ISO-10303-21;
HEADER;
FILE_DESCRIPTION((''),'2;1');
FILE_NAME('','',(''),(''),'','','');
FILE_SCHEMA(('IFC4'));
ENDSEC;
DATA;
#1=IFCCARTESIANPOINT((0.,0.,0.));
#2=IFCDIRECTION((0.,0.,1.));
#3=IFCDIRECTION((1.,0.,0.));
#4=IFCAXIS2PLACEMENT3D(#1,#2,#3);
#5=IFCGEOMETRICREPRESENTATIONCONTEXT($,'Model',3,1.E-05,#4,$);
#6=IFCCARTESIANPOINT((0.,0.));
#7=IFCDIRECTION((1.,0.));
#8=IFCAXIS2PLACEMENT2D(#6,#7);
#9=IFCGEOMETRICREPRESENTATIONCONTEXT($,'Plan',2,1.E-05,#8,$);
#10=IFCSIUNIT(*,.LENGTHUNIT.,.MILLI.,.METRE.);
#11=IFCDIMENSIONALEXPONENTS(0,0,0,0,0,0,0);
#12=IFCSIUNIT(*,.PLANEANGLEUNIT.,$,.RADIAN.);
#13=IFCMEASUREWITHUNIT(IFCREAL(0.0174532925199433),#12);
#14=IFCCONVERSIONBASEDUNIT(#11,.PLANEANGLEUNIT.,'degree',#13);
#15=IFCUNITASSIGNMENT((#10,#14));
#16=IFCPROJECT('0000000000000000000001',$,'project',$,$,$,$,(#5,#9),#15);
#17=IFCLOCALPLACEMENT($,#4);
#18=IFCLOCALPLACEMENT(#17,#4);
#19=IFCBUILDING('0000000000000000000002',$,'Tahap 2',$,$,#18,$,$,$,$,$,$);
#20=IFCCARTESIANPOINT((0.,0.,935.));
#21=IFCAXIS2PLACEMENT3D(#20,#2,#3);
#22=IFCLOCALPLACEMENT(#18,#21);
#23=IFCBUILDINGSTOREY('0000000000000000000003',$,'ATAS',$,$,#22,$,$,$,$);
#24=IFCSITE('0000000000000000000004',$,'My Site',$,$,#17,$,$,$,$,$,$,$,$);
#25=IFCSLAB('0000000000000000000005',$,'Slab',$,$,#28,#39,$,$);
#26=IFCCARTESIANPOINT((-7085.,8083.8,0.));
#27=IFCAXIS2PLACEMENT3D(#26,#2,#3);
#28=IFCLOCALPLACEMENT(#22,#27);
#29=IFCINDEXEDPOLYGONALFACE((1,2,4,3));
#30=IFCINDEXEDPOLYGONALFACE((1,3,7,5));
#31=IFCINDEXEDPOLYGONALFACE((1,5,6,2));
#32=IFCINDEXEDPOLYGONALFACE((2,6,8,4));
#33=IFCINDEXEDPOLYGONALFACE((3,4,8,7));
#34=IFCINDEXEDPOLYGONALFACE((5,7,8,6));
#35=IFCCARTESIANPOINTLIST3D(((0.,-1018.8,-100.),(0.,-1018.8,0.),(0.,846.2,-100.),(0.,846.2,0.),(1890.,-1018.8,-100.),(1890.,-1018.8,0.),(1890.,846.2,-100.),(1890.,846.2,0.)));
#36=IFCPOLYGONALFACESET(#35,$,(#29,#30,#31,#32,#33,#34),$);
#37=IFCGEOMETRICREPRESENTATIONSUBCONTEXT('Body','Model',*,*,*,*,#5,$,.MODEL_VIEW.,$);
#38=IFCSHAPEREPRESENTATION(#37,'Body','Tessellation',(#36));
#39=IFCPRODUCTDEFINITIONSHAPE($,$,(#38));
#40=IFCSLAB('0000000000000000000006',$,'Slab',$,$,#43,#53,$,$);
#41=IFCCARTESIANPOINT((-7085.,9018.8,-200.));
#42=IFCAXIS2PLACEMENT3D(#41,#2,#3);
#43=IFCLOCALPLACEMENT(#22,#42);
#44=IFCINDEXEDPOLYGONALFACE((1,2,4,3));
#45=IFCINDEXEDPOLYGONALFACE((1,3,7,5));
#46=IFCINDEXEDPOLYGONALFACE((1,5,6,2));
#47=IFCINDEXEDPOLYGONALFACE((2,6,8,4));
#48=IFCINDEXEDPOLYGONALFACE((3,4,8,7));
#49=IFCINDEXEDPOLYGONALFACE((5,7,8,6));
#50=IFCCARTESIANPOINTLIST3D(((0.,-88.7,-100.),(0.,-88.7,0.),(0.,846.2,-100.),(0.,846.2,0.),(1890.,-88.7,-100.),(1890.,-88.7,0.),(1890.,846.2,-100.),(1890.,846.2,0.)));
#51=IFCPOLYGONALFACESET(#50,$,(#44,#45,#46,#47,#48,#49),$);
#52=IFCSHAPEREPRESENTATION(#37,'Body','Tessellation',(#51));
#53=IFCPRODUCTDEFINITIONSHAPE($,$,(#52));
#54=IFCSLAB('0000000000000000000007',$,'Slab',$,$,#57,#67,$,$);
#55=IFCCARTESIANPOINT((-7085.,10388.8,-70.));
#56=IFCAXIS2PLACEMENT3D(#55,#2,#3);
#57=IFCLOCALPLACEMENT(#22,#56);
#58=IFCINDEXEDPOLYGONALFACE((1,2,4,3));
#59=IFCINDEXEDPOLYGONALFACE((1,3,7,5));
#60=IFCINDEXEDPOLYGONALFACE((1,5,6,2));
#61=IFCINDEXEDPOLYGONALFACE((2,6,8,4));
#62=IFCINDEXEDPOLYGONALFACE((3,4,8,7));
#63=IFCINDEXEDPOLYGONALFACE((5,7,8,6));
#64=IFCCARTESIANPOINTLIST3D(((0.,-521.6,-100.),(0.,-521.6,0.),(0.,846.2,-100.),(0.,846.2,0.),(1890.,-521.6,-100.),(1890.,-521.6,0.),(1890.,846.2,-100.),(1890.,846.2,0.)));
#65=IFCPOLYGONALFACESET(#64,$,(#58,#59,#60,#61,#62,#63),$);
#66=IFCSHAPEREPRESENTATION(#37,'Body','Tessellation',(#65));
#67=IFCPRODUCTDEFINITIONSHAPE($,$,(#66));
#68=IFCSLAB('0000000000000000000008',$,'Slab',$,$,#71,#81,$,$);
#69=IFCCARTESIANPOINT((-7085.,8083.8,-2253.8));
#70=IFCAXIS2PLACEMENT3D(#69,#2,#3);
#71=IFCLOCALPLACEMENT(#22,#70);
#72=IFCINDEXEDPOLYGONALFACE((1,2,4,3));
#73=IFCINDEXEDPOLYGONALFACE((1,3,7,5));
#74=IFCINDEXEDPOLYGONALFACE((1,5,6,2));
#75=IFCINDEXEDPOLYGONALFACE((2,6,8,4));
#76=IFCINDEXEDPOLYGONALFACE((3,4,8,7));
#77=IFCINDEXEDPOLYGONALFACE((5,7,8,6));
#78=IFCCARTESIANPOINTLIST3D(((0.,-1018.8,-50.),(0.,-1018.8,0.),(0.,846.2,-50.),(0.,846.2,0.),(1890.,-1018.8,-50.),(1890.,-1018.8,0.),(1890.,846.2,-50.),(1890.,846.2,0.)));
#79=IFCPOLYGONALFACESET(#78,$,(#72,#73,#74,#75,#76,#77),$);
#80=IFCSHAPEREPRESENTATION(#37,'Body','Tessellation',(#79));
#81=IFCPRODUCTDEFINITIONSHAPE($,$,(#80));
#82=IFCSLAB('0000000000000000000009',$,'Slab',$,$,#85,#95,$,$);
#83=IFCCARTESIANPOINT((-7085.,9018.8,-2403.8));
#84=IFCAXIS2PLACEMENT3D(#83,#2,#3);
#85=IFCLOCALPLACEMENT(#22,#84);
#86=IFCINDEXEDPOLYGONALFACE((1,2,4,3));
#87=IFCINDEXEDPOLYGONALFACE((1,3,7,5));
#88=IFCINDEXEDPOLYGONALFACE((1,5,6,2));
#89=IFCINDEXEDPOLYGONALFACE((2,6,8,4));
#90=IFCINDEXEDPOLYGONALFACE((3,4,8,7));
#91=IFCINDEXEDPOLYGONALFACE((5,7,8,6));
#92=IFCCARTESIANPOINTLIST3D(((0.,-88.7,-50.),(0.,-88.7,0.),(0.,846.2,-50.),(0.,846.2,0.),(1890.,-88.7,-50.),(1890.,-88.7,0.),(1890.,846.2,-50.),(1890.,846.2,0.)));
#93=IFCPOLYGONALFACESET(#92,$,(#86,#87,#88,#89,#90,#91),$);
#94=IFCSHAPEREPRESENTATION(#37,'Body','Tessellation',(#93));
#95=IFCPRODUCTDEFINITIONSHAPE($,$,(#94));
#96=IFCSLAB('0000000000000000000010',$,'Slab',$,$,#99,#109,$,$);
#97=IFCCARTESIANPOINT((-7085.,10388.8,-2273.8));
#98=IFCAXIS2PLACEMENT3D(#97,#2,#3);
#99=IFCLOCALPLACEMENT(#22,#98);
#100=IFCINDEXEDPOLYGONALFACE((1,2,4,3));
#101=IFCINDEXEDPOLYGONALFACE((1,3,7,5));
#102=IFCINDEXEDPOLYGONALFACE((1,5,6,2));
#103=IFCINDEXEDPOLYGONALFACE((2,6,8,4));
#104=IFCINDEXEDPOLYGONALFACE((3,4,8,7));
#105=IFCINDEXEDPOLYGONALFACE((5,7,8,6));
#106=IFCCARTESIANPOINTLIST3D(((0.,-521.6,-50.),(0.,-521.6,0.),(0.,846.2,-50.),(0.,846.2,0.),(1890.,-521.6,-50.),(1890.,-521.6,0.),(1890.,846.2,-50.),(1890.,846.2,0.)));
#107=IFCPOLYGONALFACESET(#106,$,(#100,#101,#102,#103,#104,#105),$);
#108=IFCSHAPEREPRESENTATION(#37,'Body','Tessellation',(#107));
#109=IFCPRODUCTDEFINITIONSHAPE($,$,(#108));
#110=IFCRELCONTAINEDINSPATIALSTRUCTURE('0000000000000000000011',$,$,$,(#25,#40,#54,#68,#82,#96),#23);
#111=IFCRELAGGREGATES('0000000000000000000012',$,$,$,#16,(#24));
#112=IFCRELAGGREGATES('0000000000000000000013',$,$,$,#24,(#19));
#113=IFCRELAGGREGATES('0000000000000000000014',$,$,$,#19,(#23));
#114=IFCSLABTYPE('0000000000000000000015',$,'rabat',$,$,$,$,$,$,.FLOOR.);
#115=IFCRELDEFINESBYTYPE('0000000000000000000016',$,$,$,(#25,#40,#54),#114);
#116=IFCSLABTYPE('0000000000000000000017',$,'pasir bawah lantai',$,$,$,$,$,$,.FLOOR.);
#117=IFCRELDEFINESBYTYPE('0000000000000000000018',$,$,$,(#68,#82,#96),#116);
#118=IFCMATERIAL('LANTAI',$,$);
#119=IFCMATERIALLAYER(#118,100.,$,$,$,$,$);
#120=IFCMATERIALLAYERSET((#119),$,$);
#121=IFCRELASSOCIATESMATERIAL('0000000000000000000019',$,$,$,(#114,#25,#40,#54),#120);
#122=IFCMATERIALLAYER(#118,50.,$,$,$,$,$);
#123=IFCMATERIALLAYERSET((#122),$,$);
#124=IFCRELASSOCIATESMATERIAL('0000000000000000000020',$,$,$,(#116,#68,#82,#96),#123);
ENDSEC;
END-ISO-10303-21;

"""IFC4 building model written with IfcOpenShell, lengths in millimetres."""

from ifc_helpers import new_model, entity, si_unit, converted_unit, frame, origin_with_axes, origin_2d_with_axis, place, context, subcontext, project, spatial, indexed_curve, outline, extrude, material, layer, layer_set, layer_usage, type_object, element, save


model = new_model("IFC4")

# Units and contexts
model_context = context("Model", 3, precision=1e-05, world=origin_with_axes())
plan_context = context("Plan", 2, precision=1e-05, world=origin_2d_with_axis())
body_context_1 = subcontext(model_context, "Body", "Model", "MODEL_VIEW")
ifc_project = project(units=[si_unit("LENGTHUNIT", "METRE", prefix="MILLI"), converted_unit("PLANEANGLEUNIT", "degree", entity("IfcReal", 0.0174532925199433), si_unit("PLANEANGLEUNIT", "RADIAN"), dimensions=[0, 0, 0, 0, 0, 0, 0])], contexts=[model_context, plan_context])

# Site, building, storey
site_placement = place(None, origin_with_axes())
site = spatial("IfcSite", under=ifc_project, at=site_placement, Name="My Site")
building_placement = place(site_placement, origin_with_axes())
building = spatial("IfcBuilding", under=site, at=building_placement, Name="Tahap 2")
storey_placement = place(building_placement, frame((0.0, 0.0, 935.0), z_axis=(0.0, 0.0, 1.0), x_axis=(1.0, 0.0, 0.0)))
storey = spatial("IfcBuildingStorey", under=building, at=storey_placement, Name="ATAS")

# Slabs
ifc_material_1 = material(Name="LANTAI")
ifc_layer_1 = layer(ifc_material_1, 100.0)
ifc_layer_set_1 = layer_set([ifc_layer_1])
slab_type_1 = type_object("IfcSlabType", Name="rabat", PredefinedType="FLOOR", material=ifc_layer_set_1)
ifc_layer_usage_1 = layer_usage(ifc_layer_set_1, "AXIS3", "NEGATIVE", 0.0)
slab_1_placement = place(storey_placement, frame((-7085.0, 8083.8, 0.0), z_axis=(0.0, 0.0, 1.0), x_axis=(1.0, 0.0, 0.0)))
element("IfcSlab", 1, at=slab_1_placement, inside=storey, type_object=slab_type_1, material=ifc_layer_usage_1, Name="Slab", context=body_context_1, shape_type="SweptSolid", body=[
    extrude(outline(indexed_curve([(0.0, -1018.8), (1890.0, -1018.8), (1890.0, 846.2), (0.0, 846.2), (0.0, -1018.8)])), None, (0.0, 0.0, -1.0), 100.0),
])
ifc_layer_usage_2 = layer_usage(ifc_layer_set_1, "AXIS3", "NEGATIVE", 0.0)
slab_2_placement = place(storey_placement, frame((-7085.0, 9018.8, -200.0), z_axis=(0.0, 0.0, 1.0), x_axis=(1.0, 0.0, 0.0)))
element("IfcSlab", 2, at=slab_2_placement, inside=storey, type_object=slab_type_1, material=ifc_layer_usage_2, Name="Slab", context=body_context_1, shape_type="SweptSolid", body=[
    extrude(outline(indexed_curve([(0.0, 846.2), (1890.0, 846.2), (1890.0, -88.7), (0.0, -88.7), (0.0, 846.2)])), None, (0.0, 0.0, -1.0), 100.0),
])
ifc_layer_usage_3 = layer_usage(ifc_layer_set_1, "AXIS3", "NEGATIVE", 0.0)
slab_3_placement = place(storey_placement, frame((-7085.0, 10388.8, -70.0), z_axis=(0.0, 0.0, 1.0), x_axis=(1.0, 0.0, 0.0)))
element("IfcSlab", 3, at=slab_3_placement, inside=storey, type_object=slab_type_1, material=ifc_layer_usage_3, Name="Slab", context=body_context_1, shape_type="SweptSolid", body=[
    extrude(outline(indexed_curve([(0.0, -521.6), (1890.0, -521.6), (1890.0, 846.2), (0.0, 846.2), (0.0, -521.6)])), None, (0.0, 0.0, -1.0), 100.0),
])
ifc_layer_2 = layer(ifc_material_1, 50.0)
ifc_layer_set_2 = layer_set([ifc_layer_2])
slab_type_2 = type_object("IfcSlabType", Name="pasir bawah lantai", PredefinedType="FLOOR", material=ifc_layer_set_2)
ifc_layer_usage_4 = layer_usage(ifc_layer_set_2, "AXIS3", "POSITIVE", -50.0)
slab_4_placement = place(storey_placement, frame((-7085.0, 8083.8, -2253.8), z_axis=(0.0, 0.0, 1.0), x_axis=(1.0, 0.0, 0.0)))
element("IfcSlab", 4, at=slab_4_placement, inside=storey, type_object=slab_type_2, material=ifc_layer_usage_4, Name="Slab", context=body_context_1, shape_type="SweptSolid", body=[
    extrude(outline(indexed_curve([(0.0, -1018.8), (1890.0, -1018.8), (1890.0, 846.2), (0.0, 846.2), (0.0, -1018.8)])), frame((0.0, 0.0, -50.0), z_axis=(0.0, 0.0, 1.0), x_axis=(1.0, 0.0, 0.0)), (0.0, 0.0, 1.0), 50.0),
])
ifc_layer_usage_5 = layer_usage(ifc_layer_set_2, "AXIS3", "POSITIVE", -50.0)
slab_5_placement = place(storey_placement, frame((-7085.0, 9018.8, -2403.8), z_axis=(0.0, 0.0, 1.0), x_axis=(1.0, 0.0, 0.0)))
element("IfcSlab", 5, at=slab_5_placement, inside=storey, type_object=slab_type_2, material=ifc_layer_usage_5, Name="Slab", context=body_context_1, shape_type="SweptSolid", body=[
    extrude(outline(indexed_curve([(0.0, 846.2), (1890.0, 846.2), (1890.0, -88.7), (0.0, -88.7), (0.0, 846.2)])), frame((0.0, 0.0, -50.0), z_axis=(0.0, 0.0, 1.0), x_axis=(1.0, 0.0, 0.0)), (0.0, 0.0, 1.0), 50.0),
])
ifc_layer_usage_6 = layer_usage(ifc_layer_set_2, "AXIS3", "POSITIVE", -50.0)
slab_6_placement = place(storey_placement, frame((-7085.0, 10388.8, -2273.8), z_axis=(0.0, 0.0, 1.0), x_axis=(1.0, 0.0, 0.0)))
element("IfcSlab", 6, at=slab_6_placement, inside=storey, type_object=slab_type_2, material=ifc_layer_usage_6, Name="Slab", context=body_context_1, shape_type="SweptSolid", body=[
    extrude(outline(indexed_curve([(0.0, -521.6), (1890.0, -521.6), (1890.0, 846.2), (0.0, 846.2), (0.0, -521.6)])), frame((0.0, 0.0, -50.0), z_axis=(0.0, 0.0, 1.0), x_axis=(1.0, 0.0, 0.0)), (0.0, 0.0, 1.0), 50.0),
])

save(model, "model.ifc")
